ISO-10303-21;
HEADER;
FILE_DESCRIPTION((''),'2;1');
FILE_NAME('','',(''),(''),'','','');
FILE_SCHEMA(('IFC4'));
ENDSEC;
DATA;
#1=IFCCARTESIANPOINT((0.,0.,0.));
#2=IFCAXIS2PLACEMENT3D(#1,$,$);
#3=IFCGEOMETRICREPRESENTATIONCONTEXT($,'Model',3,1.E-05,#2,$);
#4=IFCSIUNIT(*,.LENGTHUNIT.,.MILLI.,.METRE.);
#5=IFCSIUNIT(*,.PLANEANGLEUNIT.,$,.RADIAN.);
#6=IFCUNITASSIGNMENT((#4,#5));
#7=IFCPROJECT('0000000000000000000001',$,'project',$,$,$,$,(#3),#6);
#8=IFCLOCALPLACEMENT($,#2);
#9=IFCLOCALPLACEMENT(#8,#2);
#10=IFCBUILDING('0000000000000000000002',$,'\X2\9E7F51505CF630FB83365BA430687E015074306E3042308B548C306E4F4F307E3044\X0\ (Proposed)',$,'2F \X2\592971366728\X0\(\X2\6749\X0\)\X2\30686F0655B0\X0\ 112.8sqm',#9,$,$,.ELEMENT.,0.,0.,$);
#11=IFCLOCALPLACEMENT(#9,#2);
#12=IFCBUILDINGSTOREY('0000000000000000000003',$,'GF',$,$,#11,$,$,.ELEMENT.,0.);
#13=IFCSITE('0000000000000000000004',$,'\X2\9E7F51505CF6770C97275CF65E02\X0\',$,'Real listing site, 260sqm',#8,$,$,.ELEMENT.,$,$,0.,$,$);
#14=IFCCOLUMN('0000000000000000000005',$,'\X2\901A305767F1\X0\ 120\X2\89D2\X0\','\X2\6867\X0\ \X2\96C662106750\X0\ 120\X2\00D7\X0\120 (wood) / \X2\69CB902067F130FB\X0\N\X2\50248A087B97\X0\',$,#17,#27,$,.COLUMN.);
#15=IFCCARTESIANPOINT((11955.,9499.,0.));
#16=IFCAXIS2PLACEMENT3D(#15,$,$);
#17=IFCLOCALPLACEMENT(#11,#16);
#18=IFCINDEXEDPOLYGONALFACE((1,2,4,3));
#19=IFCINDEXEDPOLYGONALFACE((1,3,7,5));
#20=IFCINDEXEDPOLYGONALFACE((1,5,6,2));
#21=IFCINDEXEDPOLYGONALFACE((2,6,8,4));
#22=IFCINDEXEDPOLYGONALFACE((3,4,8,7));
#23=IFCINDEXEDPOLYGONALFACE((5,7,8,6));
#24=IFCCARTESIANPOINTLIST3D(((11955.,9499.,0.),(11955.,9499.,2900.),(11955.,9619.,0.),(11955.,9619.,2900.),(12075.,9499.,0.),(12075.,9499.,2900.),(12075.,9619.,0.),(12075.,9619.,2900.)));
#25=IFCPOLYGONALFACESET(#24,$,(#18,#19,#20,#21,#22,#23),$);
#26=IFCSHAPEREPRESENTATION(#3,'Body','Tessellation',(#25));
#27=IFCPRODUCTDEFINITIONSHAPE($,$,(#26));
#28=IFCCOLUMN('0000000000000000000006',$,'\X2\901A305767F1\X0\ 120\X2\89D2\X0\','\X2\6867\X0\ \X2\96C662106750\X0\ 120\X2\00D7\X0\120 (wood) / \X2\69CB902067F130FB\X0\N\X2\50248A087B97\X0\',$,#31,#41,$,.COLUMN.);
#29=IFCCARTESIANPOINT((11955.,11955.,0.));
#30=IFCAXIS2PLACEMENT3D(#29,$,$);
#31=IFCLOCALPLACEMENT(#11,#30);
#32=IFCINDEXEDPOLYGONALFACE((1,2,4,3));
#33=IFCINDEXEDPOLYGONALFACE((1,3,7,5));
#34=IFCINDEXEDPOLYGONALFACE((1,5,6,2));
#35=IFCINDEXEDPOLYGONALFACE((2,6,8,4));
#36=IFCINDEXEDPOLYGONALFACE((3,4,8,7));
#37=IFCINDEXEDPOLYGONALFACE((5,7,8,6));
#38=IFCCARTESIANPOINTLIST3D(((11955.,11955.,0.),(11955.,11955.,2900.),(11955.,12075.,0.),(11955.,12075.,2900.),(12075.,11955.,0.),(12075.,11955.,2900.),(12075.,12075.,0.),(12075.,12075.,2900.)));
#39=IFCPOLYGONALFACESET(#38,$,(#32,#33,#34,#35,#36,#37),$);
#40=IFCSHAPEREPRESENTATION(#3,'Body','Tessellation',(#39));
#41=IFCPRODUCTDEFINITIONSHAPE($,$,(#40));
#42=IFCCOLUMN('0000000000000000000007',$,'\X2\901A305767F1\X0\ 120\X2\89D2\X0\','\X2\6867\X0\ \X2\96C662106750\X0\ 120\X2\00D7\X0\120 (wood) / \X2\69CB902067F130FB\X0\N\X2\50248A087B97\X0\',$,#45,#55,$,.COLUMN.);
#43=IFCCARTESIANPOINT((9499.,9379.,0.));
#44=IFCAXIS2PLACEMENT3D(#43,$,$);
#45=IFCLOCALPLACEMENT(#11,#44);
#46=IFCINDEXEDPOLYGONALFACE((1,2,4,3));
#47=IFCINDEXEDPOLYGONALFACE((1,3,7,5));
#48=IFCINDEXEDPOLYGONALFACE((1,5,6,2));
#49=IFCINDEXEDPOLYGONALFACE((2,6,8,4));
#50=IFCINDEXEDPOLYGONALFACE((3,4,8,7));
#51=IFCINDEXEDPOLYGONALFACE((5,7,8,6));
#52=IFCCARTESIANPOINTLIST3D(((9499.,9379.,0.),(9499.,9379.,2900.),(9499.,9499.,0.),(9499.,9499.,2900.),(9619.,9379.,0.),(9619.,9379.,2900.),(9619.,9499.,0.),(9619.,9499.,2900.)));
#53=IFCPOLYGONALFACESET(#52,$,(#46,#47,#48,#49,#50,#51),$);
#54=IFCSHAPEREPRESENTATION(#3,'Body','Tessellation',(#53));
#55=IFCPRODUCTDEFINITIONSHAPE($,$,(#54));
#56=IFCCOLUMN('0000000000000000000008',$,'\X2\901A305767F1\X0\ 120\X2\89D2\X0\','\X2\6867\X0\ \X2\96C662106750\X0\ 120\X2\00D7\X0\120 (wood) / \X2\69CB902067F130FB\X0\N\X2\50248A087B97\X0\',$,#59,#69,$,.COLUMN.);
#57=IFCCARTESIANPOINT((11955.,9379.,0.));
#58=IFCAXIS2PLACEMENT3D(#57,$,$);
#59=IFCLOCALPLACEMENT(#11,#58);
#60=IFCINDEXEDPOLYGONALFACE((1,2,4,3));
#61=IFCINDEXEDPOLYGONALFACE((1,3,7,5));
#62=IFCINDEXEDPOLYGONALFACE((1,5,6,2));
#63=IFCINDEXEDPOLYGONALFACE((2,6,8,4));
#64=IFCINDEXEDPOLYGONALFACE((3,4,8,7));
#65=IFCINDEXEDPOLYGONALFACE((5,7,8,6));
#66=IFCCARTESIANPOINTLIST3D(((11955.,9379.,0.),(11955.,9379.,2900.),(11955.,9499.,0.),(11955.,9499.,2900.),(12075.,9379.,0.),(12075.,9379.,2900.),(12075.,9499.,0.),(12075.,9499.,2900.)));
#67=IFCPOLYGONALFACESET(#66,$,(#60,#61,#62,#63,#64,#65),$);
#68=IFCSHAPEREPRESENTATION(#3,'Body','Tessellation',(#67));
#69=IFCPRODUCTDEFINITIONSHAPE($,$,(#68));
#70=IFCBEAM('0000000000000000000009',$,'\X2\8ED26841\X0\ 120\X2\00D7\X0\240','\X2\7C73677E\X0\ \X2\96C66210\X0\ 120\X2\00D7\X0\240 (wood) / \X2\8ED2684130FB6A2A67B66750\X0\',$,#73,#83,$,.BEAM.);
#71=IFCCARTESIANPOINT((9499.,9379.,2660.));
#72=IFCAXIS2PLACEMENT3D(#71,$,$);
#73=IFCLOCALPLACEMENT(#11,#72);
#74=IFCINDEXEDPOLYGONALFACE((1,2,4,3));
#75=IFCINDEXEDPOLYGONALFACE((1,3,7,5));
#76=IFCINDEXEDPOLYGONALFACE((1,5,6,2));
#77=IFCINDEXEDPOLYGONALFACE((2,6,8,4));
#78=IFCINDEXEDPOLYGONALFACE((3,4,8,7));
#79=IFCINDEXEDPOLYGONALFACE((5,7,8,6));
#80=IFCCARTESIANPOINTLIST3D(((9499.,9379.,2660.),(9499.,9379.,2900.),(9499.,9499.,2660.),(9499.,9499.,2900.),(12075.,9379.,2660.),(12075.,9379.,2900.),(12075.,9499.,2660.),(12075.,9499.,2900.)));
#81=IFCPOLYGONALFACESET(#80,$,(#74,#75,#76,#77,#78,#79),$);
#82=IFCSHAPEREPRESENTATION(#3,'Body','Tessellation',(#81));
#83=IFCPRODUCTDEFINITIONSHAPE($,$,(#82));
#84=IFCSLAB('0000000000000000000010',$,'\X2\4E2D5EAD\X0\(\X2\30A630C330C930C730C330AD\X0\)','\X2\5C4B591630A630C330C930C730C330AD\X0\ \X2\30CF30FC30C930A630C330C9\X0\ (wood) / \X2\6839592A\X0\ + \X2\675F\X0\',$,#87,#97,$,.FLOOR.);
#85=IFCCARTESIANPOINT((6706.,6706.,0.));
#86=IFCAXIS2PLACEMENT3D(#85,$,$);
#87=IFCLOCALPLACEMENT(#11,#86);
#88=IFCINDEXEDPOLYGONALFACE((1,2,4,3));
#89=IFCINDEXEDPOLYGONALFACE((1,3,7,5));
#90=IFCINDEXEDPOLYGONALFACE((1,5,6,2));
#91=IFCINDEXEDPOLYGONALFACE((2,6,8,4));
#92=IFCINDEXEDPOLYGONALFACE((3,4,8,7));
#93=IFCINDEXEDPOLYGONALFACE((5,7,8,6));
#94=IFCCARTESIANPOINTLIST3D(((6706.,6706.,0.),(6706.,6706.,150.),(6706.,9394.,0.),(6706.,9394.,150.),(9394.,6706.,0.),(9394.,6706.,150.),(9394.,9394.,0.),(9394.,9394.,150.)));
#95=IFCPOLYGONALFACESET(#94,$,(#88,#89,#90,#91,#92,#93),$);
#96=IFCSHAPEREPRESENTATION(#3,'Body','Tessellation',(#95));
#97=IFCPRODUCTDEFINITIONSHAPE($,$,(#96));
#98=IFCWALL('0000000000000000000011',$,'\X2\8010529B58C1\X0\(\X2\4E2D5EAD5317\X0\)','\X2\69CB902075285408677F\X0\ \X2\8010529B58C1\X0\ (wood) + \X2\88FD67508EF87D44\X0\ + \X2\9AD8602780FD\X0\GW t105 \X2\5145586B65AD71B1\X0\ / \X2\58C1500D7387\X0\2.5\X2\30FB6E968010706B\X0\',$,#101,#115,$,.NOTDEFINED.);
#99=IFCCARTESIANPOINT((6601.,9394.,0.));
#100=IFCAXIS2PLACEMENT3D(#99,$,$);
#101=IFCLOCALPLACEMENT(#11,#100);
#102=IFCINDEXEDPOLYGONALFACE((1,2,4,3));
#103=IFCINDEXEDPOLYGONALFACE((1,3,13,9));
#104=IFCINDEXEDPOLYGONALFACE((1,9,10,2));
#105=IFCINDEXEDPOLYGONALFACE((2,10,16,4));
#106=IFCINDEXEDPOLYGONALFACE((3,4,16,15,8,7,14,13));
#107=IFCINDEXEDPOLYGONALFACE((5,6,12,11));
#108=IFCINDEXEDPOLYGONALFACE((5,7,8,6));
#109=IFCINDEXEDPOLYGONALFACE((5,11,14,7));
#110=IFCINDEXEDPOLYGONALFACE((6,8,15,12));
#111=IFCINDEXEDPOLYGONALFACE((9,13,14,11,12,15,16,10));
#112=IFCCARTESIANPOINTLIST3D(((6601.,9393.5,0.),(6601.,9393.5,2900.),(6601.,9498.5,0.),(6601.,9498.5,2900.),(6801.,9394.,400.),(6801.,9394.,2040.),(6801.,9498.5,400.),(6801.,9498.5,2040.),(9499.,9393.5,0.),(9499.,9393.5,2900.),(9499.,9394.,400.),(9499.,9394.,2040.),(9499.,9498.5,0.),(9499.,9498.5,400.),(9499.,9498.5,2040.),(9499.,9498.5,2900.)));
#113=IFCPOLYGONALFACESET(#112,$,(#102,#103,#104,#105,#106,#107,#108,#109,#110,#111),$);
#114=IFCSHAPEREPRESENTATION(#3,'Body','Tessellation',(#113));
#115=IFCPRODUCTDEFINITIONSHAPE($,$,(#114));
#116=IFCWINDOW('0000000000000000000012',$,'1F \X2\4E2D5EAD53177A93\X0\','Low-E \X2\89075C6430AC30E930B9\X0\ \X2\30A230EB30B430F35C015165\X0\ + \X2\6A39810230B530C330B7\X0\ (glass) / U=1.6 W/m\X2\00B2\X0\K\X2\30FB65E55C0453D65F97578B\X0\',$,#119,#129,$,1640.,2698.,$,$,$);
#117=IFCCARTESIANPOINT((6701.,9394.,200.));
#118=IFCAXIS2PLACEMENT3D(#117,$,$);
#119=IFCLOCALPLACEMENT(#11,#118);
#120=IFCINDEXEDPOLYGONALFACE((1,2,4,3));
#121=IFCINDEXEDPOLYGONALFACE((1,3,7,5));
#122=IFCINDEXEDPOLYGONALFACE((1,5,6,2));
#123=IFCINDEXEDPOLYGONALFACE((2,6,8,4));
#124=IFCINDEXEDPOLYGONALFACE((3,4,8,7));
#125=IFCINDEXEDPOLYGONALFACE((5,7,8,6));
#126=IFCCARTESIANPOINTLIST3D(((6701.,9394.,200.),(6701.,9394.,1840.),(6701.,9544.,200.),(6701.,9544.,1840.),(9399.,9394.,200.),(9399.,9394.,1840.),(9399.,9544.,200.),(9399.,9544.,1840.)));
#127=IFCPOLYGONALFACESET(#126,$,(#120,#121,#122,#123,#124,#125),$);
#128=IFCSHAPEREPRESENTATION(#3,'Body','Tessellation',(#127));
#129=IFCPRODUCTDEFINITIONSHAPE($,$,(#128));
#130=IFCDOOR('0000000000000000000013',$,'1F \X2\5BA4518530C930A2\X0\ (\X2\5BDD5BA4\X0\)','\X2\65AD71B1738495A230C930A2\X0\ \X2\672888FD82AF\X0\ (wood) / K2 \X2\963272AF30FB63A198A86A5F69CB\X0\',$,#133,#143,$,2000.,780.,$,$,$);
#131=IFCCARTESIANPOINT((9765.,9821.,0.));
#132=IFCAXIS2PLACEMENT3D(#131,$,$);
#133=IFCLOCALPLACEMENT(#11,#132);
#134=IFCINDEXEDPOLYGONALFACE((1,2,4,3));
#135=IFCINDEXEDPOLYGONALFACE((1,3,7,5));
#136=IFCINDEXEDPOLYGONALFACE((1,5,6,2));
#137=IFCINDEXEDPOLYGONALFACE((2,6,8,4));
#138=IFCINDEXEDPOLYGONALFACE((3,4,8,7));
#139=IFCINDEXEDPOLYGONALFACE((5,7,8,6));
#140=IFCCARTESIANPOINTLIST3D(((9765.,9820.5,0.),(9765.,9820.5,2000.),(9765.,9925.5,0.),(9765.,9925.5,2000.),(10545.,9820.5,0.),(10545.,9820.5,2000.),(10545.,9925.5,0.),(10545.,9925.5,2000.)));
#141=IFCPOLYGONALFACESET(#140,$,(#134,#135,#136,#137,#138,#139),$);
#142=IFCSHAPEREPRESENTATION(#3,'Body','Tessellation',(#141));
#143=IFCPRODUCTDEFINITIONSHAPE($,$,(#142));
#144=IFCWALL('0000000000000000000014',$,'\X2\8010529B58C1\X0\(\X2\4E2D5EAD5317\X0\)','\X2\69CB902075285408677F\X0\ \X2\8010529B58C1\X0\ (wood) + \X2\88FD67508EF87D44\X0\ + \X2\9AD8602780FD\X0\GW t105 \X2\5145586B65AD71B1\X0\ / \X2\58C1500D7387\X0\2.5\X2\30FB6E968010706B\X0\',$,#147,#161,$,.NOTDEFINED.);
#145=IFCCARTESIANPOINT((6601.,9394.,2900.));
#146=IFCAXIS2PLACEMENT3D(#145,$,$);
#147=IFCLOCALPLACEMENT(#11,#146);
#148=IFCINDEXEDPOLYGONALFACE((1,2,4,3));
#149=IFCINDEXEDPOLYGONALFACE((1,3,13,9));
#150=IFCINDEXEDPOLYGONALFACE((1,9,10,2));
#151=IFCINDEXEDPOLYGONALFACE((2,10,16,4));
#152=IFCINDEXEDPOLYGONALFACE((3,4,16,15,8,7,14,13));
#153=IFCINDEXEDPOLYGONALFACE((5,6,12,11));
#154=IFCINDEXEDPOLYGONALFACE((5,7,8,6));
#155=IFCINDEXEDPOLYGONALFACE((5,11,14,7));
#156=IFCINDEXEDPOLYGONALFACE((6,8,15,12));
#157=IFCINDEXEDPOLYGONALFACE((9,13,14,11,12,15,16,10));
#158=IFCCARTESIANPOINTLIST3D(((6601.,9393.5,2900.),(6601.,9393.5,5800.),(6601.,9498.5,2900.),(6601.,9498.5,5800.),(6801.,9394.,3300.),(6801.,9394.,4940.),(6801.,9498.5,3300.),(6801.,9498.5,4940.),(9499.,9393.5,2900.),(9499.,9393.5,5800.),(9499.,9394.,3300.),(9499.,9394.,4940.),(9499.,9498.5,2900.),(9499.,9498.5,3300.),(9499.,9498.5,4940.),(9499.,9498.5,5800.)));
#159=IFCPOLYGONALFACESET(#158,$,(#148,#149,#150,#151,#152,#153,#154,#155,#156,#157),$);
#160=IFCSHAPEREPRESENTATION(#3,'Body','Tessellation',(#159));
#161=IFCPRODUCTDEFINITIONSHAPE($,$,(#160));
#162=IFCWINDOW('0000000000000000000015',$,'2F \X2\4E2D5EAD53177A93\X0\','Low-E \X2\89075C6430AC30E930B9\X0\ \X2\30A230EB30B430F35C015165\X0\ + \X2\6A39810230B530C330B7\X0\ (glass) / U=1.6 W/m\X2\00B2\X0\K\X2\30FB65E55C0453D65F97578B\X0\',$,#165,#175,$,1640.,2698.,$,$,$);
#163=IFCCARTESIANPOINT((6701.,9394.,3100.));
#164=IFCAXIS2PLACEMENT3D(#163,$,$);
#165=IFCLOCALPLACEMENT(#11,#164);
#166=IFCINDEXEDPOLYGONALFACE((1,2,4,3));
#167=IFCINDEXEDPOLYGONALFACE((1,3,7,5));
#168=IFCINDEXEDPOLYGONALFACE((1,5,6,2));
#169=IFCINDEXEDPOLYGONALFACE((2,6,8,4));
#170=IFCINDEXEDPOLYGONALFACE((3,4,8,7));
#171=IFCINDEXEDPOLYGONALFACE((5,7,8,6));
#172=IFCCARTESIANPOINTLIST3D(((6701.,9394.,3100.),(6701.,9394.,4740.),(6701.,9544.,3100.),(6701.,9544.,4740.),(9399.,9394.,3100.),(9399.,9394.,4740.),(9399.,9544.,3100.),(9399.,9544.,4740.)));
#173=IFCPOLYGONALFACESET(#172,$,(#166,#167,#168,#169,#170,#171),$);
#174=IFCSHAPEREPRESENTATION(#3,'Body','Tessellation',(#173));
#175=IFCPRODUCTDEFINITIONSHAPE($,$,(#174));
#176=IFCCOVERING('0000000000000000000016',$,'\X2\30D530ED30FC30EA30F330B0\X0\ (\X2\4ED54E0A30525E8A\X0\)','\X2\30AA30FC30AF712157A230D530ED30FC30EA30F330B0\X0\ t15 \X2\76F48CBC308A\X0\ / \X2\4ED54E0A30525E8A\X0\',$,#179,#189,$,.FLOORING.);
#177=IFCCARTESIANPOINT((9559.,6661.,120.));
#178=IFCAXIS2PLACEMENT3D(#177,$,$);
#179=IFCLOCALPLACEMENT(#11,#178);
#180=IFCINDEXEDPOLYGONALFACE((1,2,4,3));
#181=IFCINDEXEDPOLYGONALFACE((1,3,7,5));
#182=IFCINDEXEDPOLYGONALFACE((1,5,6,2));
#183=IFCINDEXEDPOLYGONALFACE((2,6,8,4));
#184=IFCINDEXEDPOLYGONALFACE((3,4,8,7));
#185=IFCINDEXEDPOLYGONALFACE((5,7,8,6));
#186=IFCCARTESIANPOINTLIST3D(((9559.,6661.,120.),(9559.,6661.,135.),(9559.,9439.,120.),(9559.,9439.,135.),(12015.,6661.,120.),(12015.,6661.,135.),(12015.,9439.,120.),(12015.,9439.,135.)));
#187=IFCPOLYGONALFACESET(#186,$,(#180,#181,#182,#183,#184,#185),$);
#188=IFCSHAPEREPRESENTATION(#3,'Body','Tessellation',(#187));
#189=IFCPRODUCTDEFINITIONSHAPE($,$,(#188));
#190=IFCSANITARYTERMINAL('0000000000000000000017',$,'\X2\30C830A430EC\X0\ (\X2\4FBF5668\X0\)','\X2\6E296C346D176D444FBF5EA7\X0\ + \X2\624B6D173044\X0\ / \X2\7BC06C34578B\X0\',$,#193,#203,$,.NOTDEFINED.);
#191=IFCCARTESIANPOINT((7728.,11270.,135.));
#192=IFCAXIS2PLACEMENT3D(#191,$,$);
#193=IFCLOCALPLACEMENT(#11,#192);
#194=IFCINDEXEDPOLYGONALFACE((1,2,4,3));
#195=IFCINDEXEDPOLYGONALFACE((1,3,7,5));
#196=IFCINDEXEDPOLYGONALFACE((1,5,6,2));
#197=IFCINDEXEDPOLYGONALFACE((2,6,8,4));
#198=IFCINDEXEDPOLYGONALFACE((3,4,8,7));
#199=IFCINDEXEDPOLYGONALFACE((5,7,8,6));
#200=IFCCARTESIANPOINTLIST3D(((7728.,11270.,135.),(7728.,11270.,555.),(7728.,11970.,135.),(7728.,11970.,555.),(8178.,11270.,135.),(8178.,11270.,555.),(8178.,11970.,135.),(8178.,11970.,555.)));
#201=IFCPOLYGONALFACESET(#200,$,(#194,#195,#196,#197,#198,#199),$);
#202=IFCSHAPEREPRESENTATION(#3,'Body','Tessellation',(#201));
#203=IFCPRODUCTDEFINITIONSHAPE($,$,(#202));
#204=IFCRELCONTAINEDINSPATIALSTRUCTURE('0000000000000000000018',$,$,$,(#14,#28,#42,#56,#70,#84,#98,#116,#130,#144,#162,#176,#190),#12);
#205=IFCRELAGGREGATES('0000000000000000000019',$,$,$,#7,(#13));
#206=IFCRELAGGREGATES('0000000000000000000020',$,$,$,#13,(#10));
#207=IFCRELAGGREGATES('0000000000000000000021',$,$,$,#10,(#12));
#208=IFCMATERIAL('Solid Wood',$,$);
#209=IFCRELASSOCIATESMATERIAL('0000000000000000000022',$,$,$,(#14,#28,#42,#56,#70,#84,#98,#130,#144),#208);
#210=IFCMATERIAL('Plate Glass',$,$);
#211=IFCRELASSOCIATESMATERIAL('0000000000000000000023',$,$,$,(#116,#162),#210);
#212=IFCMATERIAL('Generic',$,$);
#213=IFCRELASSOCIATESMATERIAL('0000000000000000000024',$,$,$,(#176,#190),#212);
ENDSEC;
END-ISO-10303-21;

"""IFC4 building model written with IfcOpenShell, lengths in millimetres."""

from ifc_helpers import new_model, si_unit, frame, frame_2d, origin, place, context, project, spatial, rectangle, extrude, material, element, fill, save


model = new_model("IFC4")

# Units and contexts
model_context = context("Model", 3, precision=1e-05, world=origin())
ifc_project = project(units=[si_unit("LENGTHUNIT", "METRE", prefix="MILLI"), si_unit("PLANEANGLEUNIT", "RADIAN")], contexts=[model_context])

# Site, building, storey
site_placement = place(None, origin())
site = spatial("IfcSite", under=ifc_project, at=site_placement, Name="鹿児島県霧島市", ObjectType="Real listing site, 260sqm", CompositionType="ELEMENT", RefElevation=0.0)
building_placement = place(site_placement, origin())
building = spatial("IfcBuilding", under=site, at=building_placement, Name="鹿児島・茶室と縁側のある和の住まい (Proposed)", ObjectType="2F 天然木(杉)と漆喰 112.8sqm", CompositionType="ELEMENT", ElevationOfRefHeight=0.0, ElevationOfTerrain=0.0)
storey_placement = place(building_placement, origin())
storey = spatial("IfcBuildingStorey", under=building, at=storey_placement, Name="GF", CompositionType="ELEMENT", Elevation=0.0)

# Columns
ifc_material_1 = material(Name="Solid Wood")
column_1_placement = place(storey_placement, frame((11955.0, 9499.0, 0.0)))
element("IfcColumn", 1, at=column_1_placement, inside=storey, material=ifc_material_1, Name="通し柱 120角", Description="桧 集成材 120×120 (wood) / 構造柱・N値計算", PredefinedType="COLUMN", context=model_context, shape_type="SweptSolid", body=[
    extrude(rectangle(XDim=120.0, YDim=120.0, at=frame_2d((60.0, 60.0))), frame((11955.0, 9499.0, 0.0)), (0.0, 0.0, 1.0), 2900.0),
])
column_2_placement = place(storey_placement, frame((11955.0, 11955.0, 0.0)))
element("IfcColumn", 2, at=column_2_placement, inside=storey, material=ifc_material_1, Name="通し柱 120角", Description="桧 集成材 120×120 (wood) / 構造柱・N値計算", PredefinedType="COLUMN", context=model_context, shape_type="SweptSolid", body=[
    extrude(rectangle(XDim=120.0, YDim=120.0, at=frame_2d((60.0, 60.0))), frame((11955.0, 11955.0, 0.0)), (0.0, 0.0, 1.0), 2900.0),
])
column_3_placement = place(storey_placement, frame((9499.0, 9379.0, 0.0)))
element("IfcColumn", 3, at=column_3_placement, inside=storey, material=ifc_material_1, Name="通し柱 120角", Description="桧 集成材 120×120 (wood) / 構造柱・N値計算", PredefinedType="COLUMN", context=model_context, shape_type="SweptSolid", body=[
    extrude(rectangle(XDim=120.0, YDim=120.0, at=frame_2d((60.0, 60.0))), frame((9499.0, 9379.0, 0.0)), (0.0, 0.0, 1.0), 2900.0),
])
column_4_placement = place(storey_placement, frame((11955.0, 9379.0, 0.0)))
element("IfcColumn", 4, at=column_4_placement, inside=storey, material=ifc_material_1, Name="通し柱 120角", Description="桧 集成材 120×120 (wood) / 構造柱・N値計算", PredefinedType="COLUMN", context=model_context, shape_type="SweptSolid", body=[
    extrude(rectangle(XDim=120.0, YDim=120.0, at=frame_2d((60.0, 60.0))), frame((11955.0, 9379.0, 0.0)), (0.0, 0.0, 1.0), 2900.0),
])

# Beam
beam_1_placement = place(storey_placement, frame((9499.0, 9379.0, 2660.0)))
element("IfcBeam", 5, at=beam_1_placement, inside=storey, material=ifc_material_1, Name="軒桁 120×240", Description="米松 集成 120×240 (wood) / 軒桁・横架材", PredefinedType="BEAM", context=model_context, shape_type="SweptSolid", body=[
    extrude(rectangle(XDim=2576.0, YDim=120.0, at=frame_2d((1288.0, 60.0))), frame((9499.0, 9379.0, 2660.0)), (0.0, 0.0, 1.0), 240.0),
])

# Slab
slab_placement = place(storey_placement, frame((6706.0, 6706.0, 0.0)))
element("IfcSlab", 6, at=slab_placement, inside=storey, material=ifc_material_1, Name="中庭(ウッドデッキ)", Description="屋外ウッドデッキ ハードウッド (wood) / 根太 + 束", PredefinedType="FLOOR", context=model_context, shape_type="SweptSolid", body=[
    extrude(rectangle(XDim=2688.0, YDim=2688.0, at=frame_2d((1344.0, 1344.0))), frame((6706.0, 6706.0, 0.0)), (0.0, 0.0, 1.0), 150.0),
])

# Wall, opening, window
wall_1_placement = place(storey_placement, frame((6601.0, 9394.0, 0.0)))
wall_1 = element("IfcWall", 7, at=wall_1_placement, inside=storey, material=ifc_material_1, Name="耐力壁(中庭北)", Description="構造用合板 耐力壁 (wood) + 製材軸組 + 高性能GW t105 充填断熱 / 壁倍率2.5・準耐火", PredefinedType="NOTDEFINED", context=model_context, shape_type="SweptSolid", body=[
    extrude(rectangle(XDim=2898.0, YDim=105.0, at=frame_2d((1449.0, 52.0))), frame((6601.0, 9394.0, 0.0)), (0.0, 0.0, 1.0), 2900.0),
])
opening_1_placement = place(storey_placement, frame((6701.0, 9394.0, 200.0)))
opening_1 = element("IfcOpeningElement", 8, at=opening_1_placement, cuts=wall_1, PredefinedType="NOTDEFINED", context=model_context, shape_type="SweptSolid", body=[
    extrude(rectangle(XDim=2698.0, YDim=150.0, at=frame_2d((1349.0, 75.0))), frame((6701.0, 9394.0, 200.0)), (0.0, 0.0, 1.0), 1640.0),
])
ifc_material_2 = material(Name="Plate Glass")
window_1_placement = place(storey_placement, frame((6701.0, 9394.0, 200.0)))
window_1 = element("IfcWindow", 9, at=window_1_placement, inside=storey, material=ifc_material_2, Name="1F 中庭北窓", Description="Low-E 複層ガラス アルゴン封入 + 樹脂サッシ (glass) / U=1.6 W/m²K・日射取得型", OverallHeight=1640.0, OverallWidth=2698.0, context=model_context, shape_type="SweptSolid", body=[
    extrude(rectangle(XDim=2698.0, YDim=150.0, at=frame_2d((1349.0, 75.0))), frame((6701.0, 9394.0, 200.0)), (0.0, 0.0, 1.0), 1640.0),
])
fill(opening_1, window_1)

# Door
door_placement = place(storey_placement, frame((9765.0, 9821.0, 0.0)))
element("IfcDoor", 10, at=door_placement, inside=storey, material=ifc_material_1, Name="1F 室内ドア (寝室)", Description="断熱玄関ドア 木製芯 (wood) / K2 防犯・採風機構", OverallHeight=2000.0, OverallWidth=780.0, context=model_context, shape_type="SweptSolid", body=[
    extrude(rectangle(XDim=780.0, YDim=105.0, at=frame_2d((390.0, 52.0))), frame((9765.0, 9821.0, 0.0)), (0.0, 0.0, 1.0), 2000.0),
])

# Wall, opening, window
wall_2_placement = place(storey_placement, frame((6601.0, 9394.0, 2900.0)))
wall_2 = element("IfcWall", 11, at=wall_2_placement, inside=storey, material=ifc_material_1, Name="耐力壁(中庭北)", Description="構造用合板 耐力壁 (wood) + 製材軸組 + 高性能GW t105 充填断熱 / 壁倍率2.5・準耐火", PredefinedType="NOTDEFINED", context=model_context, shape_type="SweptSolid", body=[
    extrude(rectangle(XDim=2898.0, YDim=105.0, at=frame_2d((1449.0, 52.0))), frame((6601.0, 9394.0, 2900.0)), (0.0, 0.0, 1.0), 2900.0),
])
opening_2_placement = place(storey_placement, frame((6701.0, 9394.0, 3100.0)))
opening_2 = element("IfcOpeningElement", 12, at=opening_2_placement, cuts=wall_2, PredefinedType="NOTDEFINED", context=model_context, shape_type="SweptSolid", body=[
    extrude(rectangle(XDim=2698.0, YDim=150.0, at=frame_2d((1349.0, 75.0))), frame((6701.0, 9394.0, 3100.0)), (0.0, 0.0, 1.0), 1640.0),
])
window_2_placement = place(storey_placement, frame((6701.0, 9394.0, 3100.0)))
window_2 = element("IfcWindow", 13, at=window_2_placement, inside=storey, material=ifc_material_2, Name="2F 中庭北窓", Description="Low-E 複層ガラス アルゴン封入 + 樹脂サッシ (glass) / U=1.6 W/m²K・日射取得型", OverallHeight=1640.0, OverallWidth=2698.0, context=model_context, shape_type="SweptSolid", body=[
    extrude(rectangle(XDim=2698.0, YDim=150.0, at=frame_2d((1349.0, 75.0))), frame((6701.0, 9394.0, 3100.0)), (0.0, 0.0, 1.0), 1640.0),
])
fill(opening_2, window_2)

# Covering
ifc_material_3 = material(Name="Generic")
covering_placement = place(storey_placement, frame((9559.0, 6661.0, 120.0)))
element("IfcCovering", 14, at=covering_placement, inside=storey, material=ifc_material_3, Name="フローリング (仕上げ床)", Description="オーク無垢フローリング t15 直貼り / 仕上げ床", PredefinedType="FLOORING", context=model_context, shape_type="SweptSolid", body=[
    extrude(rectangle(XDim=2456.0, YDim=2778.0, at=frame_2d((1228.0, 1389.0))), frame((9559.0, 6661.0, 120.0)), (0.0, 0.0, 1.0), 15.0),
])

# Sanitary terminal
sanitary_terminal_placement = place(storey_placement, frame((7728.0, 11270.0, 135.0)))
element("IfcSanitaryTerminal", 15, at=sanitary_terminal_placement, inside=storey, material=ifc_material_3, Name="トイレ (便器)", Description="温水洗浄便座 + 手洗い / 節水型", PredefinedType="NOTDEFINED", context=model_context, shape_type="SweptSolid", body=[
    extrude(rectangle(XDim=450.0, YDim=700.0, at=frame_2d((225.0, 350.0))), frame((7728.0, 11270.0, 135.0)), (0.0, 0.0, 1.0), 420.0),
])

save(model, "model.ifc")
